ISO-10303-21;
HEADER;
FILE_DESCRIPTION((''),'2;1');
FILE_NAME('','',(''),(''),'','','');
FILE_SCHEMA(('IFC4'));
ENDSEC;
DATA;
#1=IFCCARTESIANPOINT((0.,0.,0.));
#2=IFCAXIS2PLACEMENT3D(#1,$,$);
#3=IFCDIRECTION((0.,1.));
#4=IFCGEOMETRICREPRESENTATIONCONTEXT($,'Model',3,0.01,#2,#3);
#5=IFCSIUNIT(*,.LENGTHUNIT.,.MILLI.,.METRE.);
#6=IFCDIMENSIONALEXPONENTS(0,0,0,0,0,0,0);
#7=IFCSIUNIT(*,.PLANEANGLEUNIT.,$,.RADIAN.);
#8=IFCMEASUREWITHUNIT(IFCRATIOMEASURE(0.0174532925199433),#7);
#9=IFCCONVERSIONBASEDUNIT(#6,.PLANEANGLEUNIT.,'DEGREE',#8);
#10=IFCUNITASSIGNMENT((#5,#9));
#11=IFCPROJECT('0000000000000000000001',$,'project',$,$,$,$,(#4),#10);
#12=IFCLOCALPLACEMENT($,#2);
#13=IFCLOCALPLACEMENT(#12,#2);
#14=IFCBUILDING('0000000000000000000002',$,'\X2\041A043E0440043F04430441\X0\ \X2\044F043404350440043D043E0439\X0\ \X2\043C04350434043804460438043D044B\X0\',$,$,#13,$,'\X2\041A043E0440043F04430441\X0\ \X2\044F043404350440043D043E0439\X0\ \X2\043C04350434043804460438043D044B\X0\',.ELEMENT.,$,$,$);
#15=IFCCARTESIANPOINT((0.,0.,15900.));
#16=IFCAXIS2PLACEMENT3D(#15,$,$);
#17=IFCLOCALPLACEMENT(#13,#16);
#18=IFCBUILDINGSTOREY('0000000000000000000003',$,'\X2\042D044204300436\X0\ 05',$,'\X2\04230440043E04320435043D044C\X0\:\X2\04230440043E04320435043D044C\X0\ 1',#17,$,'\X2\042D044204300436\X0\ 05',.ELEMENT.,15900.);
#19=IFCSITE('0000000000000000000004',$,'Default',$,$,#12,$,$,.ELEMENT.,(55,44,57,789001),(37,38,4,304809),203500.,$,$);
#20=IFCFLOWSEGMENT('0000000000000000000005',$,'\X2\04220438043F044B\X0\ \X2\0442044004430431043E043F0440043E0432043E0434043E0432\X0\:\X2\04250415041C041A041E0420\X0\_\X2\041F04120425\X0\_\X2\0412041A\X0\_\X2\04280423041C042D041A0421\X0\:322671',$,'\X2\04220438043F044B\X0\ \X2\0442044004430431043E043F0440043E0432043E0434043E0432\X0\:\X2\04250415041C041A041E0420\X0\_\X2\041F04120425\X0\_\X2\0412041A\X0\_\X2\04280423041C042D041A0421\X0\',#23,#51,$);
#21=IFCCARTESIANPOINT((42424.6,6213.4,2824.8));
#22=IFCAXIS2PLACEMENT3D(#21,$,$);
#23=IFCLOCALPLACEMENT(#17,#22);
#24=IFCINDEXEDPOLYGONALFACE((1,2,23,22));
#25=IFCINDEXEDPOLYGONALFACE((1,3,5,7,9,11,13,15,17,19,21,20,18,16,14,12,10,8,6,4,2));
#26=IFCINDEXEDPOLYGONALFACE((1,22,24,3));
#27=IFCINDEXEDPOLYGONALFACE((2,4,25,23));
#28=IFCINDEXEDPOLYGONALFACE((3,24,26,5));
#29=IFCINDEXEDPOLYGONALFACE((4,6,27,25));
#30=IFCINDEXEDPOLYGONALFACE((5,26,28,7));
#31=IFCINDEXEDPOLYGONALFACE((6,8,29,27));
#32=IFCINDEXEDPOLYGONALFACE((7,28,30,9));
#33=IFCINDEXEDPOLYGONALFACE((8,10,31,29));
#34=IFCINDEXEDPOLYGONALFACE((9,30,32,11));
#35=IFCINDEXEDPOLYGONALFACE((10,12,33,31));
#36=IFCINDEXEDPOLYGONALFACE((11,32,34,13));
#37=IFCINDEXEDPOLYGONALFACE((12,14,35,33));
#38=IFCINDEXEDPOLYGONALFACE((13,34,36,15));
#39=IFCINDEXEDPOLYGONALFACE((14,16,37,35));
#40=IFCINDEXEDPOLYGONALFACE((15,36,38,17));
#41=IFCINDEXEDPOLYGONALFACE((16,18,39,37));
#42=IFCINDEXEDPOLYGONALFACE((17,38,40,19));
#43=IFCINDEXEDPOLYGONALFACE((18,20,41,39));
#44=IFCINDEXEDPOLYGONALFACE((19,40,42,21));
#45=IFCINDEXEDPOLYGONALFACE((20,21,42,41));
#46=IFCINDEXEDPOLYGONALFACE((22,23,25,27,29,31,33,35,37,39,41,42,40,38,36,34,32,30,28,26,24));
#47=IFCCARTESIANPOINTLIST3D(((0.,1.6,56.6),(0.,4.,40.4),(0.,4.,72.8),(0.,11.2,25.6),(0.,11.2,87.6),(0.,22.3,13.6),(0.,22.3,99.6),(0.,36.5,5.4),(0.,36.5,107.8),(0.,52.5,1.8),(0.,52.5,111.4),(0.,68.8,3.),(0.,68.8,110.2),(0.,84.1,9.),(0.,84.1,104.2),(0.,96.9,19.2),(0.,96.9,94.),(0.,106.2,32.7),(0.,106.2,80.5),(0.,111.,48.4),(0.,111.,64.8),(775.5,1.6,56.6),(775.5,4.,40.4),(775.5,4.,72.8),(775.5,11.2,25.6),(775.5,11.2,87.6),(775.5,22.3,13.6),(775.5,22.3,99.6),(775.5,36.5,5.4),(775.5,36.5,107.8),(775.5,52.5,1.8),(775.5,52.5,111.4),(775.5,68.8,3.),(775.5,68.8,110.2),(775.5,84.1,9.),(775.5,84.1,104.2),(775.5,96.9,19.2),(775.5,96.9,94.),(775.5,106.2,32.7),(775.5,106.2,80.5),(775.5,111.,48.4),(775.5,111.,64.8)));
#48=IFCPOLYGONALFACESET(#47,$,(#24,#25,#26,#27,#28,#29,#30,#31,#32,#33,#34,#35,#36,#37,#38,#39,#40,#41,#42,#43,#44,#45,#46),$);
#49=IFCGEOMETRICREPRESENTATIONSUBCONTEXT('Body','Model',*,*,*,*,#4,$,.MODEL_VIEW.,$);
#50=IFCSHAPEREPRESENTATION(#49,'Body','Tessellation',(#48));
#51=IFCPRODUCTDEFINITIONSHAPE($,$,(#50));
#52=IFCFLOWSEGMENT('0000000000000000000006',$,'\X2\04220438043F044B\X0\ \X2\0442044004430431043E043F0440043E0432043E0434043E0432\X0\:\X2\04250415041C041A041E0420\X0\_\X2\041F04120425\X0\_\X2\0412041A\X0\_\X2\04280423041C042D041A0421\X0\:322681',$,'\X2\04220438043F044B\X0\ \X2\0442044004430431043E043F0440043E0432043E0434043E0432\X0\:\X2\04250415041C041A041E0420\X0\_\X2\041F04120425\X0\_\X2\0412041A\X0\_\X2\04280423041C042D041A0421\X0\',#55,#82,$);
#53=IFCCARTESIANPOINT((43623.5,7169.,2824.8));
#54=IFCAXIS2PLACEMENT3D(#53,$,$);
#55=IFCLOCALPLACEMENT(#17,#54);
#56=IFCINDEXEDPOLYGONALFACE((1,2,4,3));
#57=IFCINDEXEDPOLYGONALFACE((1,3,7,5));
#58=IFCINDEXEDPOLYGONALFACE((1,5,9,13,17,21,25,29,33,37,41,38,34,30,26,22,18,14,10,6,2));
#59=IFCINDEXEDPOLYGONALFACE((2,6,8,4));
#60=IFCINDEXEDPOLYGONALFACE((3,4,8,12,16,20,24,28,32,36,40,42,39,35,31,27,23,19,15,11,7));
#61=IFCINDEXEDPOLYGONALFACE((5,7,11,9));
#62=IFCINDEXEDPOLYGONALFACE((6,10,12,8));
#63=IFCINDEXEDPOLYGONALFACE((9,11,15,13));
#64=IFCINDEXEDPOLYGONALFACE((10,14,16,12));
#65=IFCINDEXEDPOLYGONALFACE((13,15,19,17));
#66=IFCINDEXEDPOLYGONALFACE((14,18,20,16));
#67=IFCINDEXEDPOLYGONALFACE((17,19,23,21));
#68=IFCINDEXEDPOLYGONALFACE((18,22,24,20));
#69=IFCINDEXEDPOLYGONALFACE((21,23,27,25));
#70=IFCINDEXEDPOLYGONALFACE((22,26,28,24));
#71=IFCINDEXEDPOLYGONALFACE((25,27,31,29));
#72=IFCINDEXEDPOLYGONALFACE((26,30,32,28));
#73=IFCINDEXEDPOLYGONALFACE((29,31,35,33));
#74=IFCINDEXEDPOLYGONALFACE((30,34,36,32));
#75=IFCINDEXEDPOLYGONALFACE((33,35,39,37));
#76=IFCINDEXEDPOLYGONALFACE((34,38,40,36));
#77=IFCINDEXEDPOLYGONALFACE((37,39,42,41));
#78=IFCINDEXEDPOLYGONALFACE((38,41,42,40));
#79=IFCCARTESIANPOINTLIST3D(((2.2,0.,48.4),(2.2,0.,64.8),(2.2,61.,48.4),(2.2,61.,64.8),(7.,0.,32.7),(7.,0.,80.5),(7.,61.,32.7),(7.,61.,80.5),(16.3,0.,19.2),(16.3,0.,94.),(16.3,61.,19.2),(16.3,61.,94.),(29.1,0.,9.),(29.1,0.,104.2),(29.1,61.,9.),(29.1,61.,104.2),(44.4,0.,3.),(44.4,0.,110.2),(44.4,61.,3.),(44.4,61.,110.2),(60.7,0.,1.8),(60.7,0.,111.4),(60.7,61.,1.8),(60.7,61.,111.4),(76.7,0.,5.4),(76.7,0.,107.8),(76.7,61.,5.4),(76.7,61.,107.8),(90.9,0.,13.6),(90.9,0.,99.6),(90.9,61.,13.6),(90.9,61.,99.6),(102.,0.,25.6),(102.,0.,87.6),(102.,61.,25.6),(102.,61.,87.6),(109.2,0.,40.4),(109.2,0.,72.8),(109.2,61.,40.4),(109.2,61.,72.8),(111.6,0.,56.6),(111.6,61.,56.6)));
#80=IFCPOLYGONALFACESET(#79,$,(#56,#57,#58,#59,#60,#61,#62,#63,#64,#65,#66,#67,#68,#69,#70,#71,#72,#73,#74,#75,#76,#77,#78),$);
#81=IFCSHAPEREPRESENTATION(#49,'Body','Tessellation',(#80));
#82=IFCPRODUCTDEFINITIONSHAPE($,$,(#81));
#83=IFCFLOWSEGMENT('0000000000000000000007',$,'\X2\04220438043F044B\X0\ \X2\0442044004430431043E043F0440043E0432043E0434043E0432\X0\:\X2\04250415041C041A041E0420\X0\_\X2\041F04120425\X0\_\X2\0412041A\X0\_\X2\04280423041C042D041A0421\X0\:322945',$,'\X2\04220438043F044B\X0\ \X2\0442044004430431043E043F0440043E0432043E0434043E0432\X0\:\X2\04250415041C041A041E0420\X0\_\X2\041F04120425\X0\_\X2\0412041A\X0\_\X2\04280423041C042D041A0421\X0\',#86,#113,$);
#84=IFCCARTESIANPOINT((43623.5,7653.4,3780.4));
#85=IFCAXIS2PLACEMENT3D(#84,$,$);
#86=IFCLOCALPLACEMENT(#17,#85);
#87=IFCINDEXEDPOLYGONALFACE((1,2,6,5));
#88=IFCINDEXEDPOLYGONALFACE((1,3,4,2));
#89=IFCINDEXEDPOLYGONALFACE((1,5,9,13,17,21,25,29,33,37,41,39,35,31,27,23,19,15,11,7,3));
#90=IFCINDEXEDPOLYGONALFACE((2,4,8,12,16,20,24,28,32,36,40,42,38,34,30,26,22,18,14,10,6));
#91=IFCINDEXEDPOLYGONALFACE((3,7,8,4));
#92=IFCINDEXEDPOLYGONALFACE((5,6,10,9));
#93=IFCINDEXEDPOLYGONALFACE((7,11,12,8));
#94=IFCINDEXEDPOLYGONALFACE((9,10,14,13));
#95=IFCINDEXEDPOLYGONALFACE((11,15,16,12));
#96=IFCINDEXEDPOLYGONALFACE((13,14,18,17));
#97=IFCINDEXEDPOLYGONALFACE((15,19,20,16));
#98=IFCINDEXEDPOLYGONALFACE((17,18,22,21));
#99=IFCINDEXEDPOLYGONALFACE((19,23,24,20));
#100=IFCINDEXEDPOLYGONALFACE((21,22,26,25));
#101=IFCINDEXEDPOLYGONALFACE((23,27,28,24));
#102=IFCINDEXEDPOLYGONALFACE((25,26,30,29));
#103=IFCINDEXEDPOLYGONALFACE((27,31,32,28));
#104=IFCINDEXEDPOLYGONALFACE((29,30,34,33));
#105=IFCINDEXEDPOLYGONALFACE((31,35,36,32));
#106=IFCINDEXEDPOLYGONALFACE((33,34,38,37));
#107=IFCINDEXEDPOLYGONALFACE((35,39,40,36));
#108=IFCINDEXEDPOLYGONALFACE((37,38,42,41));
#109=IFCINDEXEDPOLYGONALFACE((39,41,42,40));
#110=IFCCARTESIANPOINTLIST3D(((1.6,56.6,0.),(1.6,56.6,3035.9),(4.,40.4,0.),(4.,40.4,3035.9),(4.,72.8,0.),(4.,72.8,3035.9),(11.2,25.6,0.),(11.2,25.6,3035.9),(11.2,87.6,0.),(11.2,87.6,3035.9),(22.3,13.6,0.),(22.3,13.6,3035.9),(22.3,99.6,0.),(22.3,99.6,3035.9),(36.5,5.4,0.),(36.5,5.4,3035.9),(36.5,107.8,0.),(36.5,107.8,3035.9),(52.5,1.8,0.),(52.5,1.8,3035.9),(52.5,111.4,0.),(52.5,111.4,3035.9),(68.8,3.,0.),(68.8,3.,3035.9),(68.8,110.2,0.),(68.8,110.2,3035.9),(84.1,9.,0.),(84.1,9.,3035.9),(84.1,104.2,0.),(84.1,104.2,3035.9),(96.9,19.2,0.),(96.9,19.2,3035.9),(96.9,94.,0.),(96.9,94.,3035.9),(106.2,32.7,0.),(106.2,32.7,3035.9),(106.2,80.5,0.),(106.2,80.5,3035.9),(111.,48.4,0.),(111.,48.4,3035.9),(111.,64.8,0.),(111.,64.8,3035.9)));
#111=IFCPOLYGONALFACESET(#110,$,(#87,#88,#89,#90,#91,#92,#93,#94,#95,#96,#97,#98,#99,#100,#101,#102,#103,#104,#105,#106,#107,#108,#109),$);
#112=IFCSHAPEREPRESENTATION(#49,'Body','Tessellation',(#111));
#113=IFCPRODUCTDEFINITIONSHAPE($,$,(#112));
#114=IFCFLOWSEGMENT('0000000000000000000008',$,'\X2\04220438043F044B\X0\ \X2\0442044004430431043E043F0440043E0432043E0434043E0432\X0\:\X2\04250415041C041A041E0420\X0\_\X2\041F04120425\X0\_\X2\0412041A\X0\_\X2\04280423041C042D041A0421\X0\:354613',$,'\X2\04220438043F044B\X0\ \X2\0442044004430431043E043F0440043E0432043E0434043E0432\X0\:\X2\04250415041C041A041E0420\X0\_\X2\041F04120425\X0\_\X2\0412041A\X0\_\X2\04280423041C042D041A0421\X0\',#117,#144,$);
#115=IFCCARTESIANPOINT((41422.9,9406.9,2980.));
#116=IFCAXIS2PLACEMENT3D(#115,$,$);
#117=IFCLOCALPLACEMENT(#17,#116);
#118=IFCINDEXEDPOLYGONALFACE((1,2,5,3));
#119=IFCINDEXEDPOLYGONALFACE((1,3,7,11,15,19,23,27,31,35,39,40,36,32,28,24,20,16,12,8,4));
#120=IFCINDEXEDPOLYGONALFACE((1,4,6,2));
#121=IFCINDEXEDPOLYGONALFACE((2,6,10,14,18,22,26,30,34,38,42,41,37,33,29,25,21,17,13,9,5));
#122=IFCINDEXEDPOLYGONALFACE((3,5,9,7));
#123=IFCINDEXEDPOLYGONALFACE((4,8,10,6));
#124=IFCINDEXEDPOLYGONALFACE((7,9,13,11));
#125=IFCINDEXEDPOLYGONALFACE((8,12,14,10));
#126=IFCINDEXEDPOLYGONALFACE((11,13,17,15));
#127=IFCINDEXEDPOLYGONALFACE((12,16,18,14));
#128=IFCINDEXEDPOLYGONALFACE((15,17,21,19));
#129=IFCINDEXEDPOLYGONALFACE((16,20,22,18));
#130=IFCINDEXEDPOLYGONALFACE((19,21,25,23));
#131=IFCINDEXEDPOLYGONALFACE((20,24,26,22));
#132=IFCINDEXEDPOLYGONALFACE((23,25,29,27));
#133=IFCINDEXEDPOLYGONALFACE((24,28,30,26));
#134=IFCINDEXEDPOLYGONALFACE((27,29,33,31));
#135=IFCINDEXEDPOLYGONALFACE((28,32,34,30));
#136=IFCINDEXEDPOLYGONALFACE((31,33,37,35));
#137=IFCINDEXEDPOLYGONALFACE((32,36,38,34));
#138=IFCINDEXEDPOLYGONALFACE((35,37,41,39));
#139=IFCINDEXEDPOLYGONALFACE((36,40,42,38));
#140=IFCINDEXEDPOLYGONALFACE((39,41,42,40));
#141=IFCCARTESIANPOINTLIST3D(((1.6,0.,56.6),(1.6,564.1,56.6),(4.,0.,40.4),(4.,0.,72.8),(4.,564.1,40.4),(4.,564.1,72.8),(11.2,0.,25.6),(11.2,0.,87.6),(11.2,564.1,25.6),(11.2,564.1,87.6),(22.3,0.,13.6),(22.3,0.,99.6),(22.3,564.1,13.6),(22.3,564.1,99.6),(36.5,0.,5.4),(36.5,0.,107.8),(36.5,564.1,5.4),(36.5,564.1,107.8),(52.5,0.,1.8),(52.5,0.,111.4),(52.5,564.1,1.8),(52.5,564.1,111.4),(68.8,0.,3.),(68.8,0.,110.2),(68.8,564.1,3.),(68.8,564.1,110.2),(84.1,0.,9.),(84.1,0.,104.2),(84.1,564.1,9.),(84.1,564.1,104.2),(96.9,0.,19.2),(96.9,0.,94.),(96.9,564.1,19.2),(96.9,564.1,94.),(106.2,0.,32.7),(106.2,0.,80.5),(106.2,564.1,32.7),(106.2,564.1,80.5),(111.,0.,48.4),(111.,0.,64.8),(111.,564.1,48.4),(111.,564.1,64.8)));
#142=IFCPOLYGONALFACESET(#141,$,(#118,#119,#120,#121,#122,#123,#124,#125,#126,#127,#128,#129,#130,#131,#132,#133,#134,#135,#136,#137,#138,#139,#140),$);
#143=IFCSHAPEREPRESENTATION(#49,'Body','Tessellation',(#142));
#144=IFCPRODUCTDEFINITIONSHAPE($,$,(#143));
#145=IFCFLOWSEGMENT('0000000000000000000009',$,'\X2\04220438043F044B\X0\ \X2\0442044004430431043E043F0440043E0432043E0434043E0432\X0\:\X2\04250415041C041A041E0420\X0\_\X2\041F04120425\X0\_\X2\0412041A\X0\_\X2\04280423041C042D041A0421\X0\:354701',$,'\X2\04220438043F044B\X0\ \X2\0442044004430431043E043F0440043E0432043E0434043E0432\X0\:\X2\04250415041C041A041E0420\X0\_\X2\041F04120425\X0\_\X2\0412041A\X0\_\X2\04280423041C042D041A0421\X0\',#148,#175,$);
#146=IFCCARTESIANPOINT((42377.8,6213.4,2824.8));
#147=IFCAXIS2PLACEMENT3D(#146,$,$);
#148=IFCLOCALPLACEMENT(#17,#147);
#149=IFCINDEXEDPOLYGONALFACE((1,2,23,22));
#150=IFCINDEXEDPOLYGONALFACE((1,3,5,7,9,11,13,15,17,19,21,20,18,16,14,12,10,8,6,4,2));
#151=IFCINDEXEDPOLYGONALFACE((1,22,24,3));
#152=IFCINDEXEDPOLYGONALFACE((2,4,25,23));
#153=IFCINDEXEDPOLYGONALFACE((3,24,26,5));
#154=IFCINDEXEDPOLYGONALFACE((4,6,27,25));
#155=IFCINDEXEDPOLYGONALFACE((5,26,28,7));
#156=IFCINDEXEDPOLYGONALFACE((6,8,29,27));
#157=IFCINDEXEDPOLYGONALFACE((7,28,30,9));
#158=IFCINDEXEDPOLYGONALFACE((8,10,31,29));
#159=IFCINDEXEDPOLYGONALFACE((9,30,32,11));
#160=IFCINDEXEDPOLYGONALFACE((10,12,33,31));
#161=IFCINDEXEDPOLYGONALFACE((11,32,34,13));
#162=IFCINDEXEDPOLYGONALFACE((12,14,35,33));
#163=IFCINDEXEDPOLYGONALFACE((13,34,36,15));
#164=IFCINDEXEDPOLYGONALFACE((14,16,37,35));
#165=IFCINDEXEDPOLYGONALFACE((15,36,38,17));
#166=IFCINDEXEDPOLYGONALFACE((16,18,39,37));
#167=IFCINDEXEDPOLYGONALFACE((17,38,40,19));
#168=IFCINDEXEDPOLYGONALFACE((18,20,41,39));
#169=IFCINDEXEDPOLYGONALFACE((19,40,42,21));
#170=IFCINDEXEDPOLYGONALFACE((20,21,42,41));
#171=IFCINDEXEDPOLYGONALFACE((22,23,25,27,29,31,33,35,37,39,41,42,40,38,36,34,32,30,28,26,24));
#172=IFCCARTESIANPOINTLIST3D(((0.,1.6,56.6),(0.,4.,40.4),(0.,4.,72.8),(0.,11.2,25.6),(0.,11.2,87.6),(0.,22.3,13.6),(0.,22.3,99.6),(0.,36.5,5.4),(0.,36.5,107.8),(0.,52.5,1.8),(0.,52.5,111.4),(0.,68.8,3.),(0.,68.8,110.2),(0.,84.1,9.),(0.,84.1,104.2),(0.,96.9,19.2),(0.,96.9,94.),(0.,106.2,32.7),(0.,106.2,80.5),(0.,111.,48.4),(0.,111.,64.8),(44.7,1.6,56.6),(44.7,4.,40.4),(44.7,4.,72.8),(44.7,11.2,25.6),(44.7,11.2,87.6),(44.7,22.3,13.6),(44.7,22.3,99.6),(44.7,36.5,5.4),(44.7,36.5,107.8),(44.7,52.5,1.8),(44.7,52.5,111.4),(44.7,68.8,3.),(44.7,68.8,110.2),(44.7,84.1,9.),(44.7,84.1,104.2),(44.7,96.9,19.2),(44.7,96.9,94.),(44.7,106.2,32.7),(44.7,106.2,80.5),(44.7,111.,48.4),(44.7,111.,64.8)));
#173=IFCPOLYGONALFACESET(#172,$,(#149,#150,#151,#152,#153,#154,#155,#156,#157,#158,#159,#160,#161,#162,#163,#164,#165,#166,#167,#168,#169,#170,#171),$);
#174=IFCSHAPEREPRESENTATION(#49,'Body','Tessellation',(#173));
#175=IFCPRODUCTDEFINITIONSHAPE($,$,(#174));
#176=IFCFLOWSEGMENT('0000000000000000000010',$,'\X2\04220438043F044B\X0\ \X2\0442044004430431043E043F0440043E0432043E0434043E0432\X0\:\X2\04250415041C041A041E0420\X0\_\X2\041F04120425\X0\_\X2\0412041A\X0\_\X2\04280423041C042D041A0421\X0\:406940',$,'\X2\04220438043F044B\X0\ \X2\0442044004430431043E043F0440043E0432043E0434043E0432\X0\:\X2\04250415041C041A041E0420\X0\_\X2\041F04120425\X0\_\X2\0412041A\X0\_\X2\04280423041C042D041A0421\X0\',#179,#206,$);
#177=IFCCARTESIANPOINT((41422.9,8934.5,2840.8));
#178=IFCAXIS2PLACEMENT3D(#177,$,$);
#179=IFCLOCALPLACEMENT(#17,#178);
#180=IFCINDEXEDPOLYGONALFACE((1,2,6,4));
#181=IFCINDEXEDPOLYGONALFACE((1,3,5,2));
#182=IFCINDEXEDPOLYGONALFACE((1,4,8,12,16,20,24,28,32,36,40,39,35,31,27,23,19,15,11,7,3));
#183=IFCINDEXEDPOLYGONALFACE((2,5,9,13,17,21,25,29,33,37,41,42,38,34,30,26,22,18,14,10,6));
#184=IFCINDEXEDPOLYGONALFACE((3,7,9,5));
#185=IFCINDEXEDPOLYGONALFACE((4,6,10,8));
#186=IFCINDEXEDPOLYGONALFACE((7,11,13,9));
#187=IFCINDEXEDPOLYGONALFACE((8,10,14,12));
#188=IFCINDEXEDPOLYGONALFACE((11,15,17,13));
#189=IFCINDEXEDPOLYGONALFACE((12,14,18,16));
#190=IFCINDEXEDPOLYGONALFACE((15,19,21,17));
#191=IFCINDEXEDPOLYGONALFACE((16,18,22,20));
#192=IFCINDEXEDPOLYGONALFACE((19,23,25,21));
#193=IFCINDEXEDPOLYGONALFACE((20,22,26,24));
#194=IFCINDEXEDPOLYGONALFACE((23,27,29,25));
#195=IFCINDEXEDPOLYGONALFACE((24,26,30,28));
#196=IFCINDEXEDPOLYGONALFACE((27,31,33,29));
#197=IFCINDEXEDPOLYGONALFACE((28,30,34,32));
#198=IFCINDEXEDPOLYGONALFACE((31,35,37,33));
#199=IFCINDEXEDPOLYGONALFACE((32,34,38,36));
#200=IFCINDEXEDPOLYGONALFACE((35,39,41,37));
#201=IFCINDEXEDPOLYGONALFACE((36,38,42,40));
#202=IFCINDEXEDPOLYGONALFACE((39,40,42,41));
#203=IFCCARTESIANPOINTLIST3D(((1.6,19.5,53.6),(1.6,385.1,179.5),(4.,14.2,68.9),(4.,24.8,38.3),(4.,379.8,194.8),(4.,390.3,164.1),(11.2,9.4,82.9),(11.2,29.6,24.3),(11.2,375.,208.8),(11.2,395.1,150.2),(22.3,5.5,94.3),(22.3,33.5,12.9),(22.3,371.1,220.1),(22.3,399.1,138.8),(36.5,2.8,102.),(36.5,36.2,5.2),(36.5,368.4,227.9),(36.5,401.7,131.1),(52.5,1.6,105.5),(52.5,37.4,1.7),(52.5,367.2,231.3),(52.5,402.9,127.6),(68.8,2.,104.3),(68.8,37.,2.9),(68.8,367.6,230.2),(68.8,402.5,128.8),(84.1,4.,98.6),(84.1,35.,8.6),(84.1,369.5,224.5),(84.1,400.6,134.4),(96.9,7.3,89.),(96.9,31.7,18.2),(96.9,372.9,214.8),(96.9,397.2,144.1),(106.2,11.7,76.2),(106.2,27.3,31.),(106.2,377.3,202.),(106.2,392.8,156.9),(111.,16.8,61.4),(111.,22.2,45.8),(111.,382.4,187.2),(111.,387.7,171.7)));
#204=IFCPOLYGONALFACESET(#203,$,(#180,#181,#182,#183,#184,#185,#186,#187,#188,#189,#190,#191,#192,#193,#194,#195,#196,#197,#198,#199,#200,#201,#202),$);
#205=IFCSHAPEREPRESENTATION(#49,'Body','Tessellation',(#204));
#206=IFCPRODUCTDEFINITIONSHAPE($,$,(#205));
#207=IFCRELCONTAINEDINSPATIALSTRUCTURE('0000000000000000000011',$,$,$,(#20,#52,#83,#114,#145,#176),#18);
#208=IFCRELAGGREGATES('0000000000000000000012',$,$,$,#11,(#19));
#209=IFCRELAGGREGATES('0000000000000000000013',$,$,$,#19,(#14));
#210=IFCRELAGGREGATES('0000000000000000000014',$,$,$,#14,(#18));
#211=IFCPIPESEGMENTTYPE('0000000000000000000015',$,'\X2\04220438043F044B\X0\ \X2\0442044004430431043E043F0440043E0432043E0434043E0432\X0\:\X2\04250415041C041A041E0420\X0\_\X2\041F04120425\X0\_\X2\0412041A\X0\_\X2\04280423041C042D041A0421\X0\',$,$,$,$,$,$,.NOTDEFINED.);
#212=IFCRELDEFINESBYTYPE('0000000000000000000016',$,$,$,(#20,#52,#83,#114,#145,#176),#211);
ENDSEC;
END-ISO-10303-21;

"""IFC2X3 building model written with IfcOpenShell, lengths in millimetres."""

from ifc_helpers import new_model, entity, si_unit, converted_unit, direction, frame, origin, origin_2d_with_axis, place, context, subcontext, project, spatial, circle, extrude, type_object, element, save


model = new_model("IFC2X3")

# Units and contexts
model_context = context("Model", 3, precision=0.01, world=origin(), true_north=direction((0.0, 1.0)))
body_context = subcontext(model_context, "Body", "Model", "MODEL_VIEW")
ifc_project = project(units=[si_unit("LENGTHUNIT", "METRE", prefix="MILLI"), converted_unit("PLANEANGLEUNIT", "DEGREE", entity("IfcRatioMeasure", 0.0174532925199433), si_unit("PLANEANGLEUNIT", "RADIAN"), dimensions=[0, 0, 0, 0, 0, 0, 0])], contexts=[model_context])

# Site, building, storey
site_placement = place(None, origin())
site = spatial("IfcSite", under=ifc_project, at=site_placement, Name="Default", CompositionType="ELEMENT", RefLatitude=(55, 44, 57, 789001), RefLongitude=(37, 38, 4, 304809), RefElevation=203500.0)
building_placement = place(site_placement, origin())
building = spatial("IfcBuilding", under=site, at=building_placement, Name="Корпус ядерной медицины", LongName="Корпус ядерной медицины", CompositionType="ELEMENT")
storey_placement = place(building_placement, frame((0.0, 0.0, 15900.0)))
storey = spatial("IfcBuildingStorey", under=building, at=storey_placement, Name="Этаж 05", ObjectType="Уровень:Уровень 1", LongName="Этаж 05", CompositionType="ELEMENT", Elevation=15900.0)

# Flow segments
pipe_segment_type = type_object("IfcPipeSegmentType", Name="Типы трубопроводов:ХЕМКОР_ПВХ_ВК_ШУМЭКС", PredefinedType="NOTDEFINED")
flow_segment_1_placement = place(storey_placement, frame((42424.6, 6213.4, 2824.8)))
element("IfcFlowSegment", 1, at=flow_segment_1_placement, inside=storey, type_object=pipe_segment_type, Name="Типы трубопроводов:ХЕМКОР_ПВХ_ВК_ШУМЭКС:322671", ObjectType="Типы трубопроводов:ХЕМКОР_ПВХ_ВК_ШУМЭКС", context=body_context, shape_type="SweptSolid", body=[
    extrude(circle(Radius=55.0, at=origin_2d_with_axis()), frame((0.0, 56.6, 56.6), z_axis=(1.0, 0.0, 0.0), x_axis=(0.0, -1.0, 0.0)), (0.0, 0.0, 1.0), 775.5),
])
flow_segment_2_placement = place(storey_placement, frame((43623.5, 7169.0, 2824.8)))
element("IfcFlowSegment", 2, at=flow_segment_2_placement, inside=storey, type_object=pipe_segment_type, Name="Типы трубопроводов:ХЕМКОР_ПВХ_ВК_ШУМЭКС:322681", ObjectType="Типы трубопроводов:ХЕМКОР_ПВХ_ВК_ШУМЭКС", context=body_context, shape_type="SweptSolid", body=[
    extrude(circle(Radius=55.0, at=origin_2d_with_axis()), frame((56.6, 0.0, 56.6), z_axis=(0.0, 1.0, 0.0), x_axis=(1.0, 0.0, 0.0)), (0.0, 0.0, 1.0), 61.0),
])
flow_segment_3_placement = place(storey_placement, frame((43623.5, 7653.4, 3780.4)))
element("IfcFlowSegment", 3, at=flow_segment_3_placement, inside=storey, type_object=pipe_segment_type, Name="Типы трубопроводов:ХЕМКОР_ПВХ_ВК_ШУМЭКС:322945", ObjectType="Типы трубопроводов:ХЕМКОР_ПВХ_ВК_ШУМЭКС", context=body_context, shape_type="SweptSolid", body=[
    extrude(circle(Radius=55.0, at=origin_2d_with_axis()), frame((56.6, 56.6, 0.0), z_axis=(0.0, 0.0, 1.0), x_axis=(-1.0, 0.0, 0.0)), (0.0, 0.0, 1.0), 3035.9),
])
flow_segment_4_placement = place(storey_placement, frame((41422.9, 9406.9, 2980.0)))
element("IfcFlowSegment", 4, at=flow_segment_4_placement, inside=storey, type_object=pipe_segment_type, Name="Типы трубопроводов:ХЕМКОР_ПВХ_ВК_ШУМЭКС:354613", ObjectType="Типы трубопроводов:ХЕМКОР_ПВХ_ВК_ШУМЭКС", context=body_context, shape_type="SweptSolid", body=[
    extrude(circle(Radius=55.0, at=origin_2d_with_axis()), frame((56.6, 0.0, 56.6), z_axis=(0.0, 1.0, 0.0), x_axis=(-1.0, 0.0, 0.0)), (0.0, 0.0, 1.0), 564.1),
])
flow_segment_5_placement = place(storey_placement, frame((42377.8, 6213.4, 2824.8)))
element("IfcFlowSegment", 5, at=flow_segment_5_placement, inside=storey, type_object=pipe_segment_type, Name="Типы трубопроводов:ХЕМКОР_ПВХ_ВК_ШУМЭКС:354701", ObjectType="Типы трубопроводов:ХЕМКОР_ПВХ_ВК_ШУМЭКС", context=body_context, shape_type="SweptSolid", body=[
    extrude(circle(Radius=55.0, at=origin_2d_with_axis()), frame((0.0, 56.6, 56.6), z_axis=(1.0, 0.0, 0.0), x_axis=(0.0, -1.0, 0.0)), (0.0, 0.0, 1.0), 44.7),
])
flow_segment_6_placement = place(storey_placement, frame((41422.9, 8934.5, 2840.8)))
element("IfcFlowSegment", 6, at=flow_segment_6_placement, inside=storey, type_object=pipe_segment_type, Name="Типы трубопроводов:ХЕМКОР_ПВХ_ВК_ШУМЭКС:406940", ObjectType="Типы трубопроводов:ХЕМКОР_ПВХ_ВК_ШУМЭКС", context=body_context, shape_type="SweptSolid", body=[
    extrude(circle(Radius=55.0, at=origin_2d_with_axis()), frame((56.6, 19.5, 53.6), z_axis=(0.0, 0.945519, 0.325568), x_axis=(-1.0, 0.0, 0.0)), (0.0, 0.0, 1.0), 386.6),
])

save(model, "model.ifc")
